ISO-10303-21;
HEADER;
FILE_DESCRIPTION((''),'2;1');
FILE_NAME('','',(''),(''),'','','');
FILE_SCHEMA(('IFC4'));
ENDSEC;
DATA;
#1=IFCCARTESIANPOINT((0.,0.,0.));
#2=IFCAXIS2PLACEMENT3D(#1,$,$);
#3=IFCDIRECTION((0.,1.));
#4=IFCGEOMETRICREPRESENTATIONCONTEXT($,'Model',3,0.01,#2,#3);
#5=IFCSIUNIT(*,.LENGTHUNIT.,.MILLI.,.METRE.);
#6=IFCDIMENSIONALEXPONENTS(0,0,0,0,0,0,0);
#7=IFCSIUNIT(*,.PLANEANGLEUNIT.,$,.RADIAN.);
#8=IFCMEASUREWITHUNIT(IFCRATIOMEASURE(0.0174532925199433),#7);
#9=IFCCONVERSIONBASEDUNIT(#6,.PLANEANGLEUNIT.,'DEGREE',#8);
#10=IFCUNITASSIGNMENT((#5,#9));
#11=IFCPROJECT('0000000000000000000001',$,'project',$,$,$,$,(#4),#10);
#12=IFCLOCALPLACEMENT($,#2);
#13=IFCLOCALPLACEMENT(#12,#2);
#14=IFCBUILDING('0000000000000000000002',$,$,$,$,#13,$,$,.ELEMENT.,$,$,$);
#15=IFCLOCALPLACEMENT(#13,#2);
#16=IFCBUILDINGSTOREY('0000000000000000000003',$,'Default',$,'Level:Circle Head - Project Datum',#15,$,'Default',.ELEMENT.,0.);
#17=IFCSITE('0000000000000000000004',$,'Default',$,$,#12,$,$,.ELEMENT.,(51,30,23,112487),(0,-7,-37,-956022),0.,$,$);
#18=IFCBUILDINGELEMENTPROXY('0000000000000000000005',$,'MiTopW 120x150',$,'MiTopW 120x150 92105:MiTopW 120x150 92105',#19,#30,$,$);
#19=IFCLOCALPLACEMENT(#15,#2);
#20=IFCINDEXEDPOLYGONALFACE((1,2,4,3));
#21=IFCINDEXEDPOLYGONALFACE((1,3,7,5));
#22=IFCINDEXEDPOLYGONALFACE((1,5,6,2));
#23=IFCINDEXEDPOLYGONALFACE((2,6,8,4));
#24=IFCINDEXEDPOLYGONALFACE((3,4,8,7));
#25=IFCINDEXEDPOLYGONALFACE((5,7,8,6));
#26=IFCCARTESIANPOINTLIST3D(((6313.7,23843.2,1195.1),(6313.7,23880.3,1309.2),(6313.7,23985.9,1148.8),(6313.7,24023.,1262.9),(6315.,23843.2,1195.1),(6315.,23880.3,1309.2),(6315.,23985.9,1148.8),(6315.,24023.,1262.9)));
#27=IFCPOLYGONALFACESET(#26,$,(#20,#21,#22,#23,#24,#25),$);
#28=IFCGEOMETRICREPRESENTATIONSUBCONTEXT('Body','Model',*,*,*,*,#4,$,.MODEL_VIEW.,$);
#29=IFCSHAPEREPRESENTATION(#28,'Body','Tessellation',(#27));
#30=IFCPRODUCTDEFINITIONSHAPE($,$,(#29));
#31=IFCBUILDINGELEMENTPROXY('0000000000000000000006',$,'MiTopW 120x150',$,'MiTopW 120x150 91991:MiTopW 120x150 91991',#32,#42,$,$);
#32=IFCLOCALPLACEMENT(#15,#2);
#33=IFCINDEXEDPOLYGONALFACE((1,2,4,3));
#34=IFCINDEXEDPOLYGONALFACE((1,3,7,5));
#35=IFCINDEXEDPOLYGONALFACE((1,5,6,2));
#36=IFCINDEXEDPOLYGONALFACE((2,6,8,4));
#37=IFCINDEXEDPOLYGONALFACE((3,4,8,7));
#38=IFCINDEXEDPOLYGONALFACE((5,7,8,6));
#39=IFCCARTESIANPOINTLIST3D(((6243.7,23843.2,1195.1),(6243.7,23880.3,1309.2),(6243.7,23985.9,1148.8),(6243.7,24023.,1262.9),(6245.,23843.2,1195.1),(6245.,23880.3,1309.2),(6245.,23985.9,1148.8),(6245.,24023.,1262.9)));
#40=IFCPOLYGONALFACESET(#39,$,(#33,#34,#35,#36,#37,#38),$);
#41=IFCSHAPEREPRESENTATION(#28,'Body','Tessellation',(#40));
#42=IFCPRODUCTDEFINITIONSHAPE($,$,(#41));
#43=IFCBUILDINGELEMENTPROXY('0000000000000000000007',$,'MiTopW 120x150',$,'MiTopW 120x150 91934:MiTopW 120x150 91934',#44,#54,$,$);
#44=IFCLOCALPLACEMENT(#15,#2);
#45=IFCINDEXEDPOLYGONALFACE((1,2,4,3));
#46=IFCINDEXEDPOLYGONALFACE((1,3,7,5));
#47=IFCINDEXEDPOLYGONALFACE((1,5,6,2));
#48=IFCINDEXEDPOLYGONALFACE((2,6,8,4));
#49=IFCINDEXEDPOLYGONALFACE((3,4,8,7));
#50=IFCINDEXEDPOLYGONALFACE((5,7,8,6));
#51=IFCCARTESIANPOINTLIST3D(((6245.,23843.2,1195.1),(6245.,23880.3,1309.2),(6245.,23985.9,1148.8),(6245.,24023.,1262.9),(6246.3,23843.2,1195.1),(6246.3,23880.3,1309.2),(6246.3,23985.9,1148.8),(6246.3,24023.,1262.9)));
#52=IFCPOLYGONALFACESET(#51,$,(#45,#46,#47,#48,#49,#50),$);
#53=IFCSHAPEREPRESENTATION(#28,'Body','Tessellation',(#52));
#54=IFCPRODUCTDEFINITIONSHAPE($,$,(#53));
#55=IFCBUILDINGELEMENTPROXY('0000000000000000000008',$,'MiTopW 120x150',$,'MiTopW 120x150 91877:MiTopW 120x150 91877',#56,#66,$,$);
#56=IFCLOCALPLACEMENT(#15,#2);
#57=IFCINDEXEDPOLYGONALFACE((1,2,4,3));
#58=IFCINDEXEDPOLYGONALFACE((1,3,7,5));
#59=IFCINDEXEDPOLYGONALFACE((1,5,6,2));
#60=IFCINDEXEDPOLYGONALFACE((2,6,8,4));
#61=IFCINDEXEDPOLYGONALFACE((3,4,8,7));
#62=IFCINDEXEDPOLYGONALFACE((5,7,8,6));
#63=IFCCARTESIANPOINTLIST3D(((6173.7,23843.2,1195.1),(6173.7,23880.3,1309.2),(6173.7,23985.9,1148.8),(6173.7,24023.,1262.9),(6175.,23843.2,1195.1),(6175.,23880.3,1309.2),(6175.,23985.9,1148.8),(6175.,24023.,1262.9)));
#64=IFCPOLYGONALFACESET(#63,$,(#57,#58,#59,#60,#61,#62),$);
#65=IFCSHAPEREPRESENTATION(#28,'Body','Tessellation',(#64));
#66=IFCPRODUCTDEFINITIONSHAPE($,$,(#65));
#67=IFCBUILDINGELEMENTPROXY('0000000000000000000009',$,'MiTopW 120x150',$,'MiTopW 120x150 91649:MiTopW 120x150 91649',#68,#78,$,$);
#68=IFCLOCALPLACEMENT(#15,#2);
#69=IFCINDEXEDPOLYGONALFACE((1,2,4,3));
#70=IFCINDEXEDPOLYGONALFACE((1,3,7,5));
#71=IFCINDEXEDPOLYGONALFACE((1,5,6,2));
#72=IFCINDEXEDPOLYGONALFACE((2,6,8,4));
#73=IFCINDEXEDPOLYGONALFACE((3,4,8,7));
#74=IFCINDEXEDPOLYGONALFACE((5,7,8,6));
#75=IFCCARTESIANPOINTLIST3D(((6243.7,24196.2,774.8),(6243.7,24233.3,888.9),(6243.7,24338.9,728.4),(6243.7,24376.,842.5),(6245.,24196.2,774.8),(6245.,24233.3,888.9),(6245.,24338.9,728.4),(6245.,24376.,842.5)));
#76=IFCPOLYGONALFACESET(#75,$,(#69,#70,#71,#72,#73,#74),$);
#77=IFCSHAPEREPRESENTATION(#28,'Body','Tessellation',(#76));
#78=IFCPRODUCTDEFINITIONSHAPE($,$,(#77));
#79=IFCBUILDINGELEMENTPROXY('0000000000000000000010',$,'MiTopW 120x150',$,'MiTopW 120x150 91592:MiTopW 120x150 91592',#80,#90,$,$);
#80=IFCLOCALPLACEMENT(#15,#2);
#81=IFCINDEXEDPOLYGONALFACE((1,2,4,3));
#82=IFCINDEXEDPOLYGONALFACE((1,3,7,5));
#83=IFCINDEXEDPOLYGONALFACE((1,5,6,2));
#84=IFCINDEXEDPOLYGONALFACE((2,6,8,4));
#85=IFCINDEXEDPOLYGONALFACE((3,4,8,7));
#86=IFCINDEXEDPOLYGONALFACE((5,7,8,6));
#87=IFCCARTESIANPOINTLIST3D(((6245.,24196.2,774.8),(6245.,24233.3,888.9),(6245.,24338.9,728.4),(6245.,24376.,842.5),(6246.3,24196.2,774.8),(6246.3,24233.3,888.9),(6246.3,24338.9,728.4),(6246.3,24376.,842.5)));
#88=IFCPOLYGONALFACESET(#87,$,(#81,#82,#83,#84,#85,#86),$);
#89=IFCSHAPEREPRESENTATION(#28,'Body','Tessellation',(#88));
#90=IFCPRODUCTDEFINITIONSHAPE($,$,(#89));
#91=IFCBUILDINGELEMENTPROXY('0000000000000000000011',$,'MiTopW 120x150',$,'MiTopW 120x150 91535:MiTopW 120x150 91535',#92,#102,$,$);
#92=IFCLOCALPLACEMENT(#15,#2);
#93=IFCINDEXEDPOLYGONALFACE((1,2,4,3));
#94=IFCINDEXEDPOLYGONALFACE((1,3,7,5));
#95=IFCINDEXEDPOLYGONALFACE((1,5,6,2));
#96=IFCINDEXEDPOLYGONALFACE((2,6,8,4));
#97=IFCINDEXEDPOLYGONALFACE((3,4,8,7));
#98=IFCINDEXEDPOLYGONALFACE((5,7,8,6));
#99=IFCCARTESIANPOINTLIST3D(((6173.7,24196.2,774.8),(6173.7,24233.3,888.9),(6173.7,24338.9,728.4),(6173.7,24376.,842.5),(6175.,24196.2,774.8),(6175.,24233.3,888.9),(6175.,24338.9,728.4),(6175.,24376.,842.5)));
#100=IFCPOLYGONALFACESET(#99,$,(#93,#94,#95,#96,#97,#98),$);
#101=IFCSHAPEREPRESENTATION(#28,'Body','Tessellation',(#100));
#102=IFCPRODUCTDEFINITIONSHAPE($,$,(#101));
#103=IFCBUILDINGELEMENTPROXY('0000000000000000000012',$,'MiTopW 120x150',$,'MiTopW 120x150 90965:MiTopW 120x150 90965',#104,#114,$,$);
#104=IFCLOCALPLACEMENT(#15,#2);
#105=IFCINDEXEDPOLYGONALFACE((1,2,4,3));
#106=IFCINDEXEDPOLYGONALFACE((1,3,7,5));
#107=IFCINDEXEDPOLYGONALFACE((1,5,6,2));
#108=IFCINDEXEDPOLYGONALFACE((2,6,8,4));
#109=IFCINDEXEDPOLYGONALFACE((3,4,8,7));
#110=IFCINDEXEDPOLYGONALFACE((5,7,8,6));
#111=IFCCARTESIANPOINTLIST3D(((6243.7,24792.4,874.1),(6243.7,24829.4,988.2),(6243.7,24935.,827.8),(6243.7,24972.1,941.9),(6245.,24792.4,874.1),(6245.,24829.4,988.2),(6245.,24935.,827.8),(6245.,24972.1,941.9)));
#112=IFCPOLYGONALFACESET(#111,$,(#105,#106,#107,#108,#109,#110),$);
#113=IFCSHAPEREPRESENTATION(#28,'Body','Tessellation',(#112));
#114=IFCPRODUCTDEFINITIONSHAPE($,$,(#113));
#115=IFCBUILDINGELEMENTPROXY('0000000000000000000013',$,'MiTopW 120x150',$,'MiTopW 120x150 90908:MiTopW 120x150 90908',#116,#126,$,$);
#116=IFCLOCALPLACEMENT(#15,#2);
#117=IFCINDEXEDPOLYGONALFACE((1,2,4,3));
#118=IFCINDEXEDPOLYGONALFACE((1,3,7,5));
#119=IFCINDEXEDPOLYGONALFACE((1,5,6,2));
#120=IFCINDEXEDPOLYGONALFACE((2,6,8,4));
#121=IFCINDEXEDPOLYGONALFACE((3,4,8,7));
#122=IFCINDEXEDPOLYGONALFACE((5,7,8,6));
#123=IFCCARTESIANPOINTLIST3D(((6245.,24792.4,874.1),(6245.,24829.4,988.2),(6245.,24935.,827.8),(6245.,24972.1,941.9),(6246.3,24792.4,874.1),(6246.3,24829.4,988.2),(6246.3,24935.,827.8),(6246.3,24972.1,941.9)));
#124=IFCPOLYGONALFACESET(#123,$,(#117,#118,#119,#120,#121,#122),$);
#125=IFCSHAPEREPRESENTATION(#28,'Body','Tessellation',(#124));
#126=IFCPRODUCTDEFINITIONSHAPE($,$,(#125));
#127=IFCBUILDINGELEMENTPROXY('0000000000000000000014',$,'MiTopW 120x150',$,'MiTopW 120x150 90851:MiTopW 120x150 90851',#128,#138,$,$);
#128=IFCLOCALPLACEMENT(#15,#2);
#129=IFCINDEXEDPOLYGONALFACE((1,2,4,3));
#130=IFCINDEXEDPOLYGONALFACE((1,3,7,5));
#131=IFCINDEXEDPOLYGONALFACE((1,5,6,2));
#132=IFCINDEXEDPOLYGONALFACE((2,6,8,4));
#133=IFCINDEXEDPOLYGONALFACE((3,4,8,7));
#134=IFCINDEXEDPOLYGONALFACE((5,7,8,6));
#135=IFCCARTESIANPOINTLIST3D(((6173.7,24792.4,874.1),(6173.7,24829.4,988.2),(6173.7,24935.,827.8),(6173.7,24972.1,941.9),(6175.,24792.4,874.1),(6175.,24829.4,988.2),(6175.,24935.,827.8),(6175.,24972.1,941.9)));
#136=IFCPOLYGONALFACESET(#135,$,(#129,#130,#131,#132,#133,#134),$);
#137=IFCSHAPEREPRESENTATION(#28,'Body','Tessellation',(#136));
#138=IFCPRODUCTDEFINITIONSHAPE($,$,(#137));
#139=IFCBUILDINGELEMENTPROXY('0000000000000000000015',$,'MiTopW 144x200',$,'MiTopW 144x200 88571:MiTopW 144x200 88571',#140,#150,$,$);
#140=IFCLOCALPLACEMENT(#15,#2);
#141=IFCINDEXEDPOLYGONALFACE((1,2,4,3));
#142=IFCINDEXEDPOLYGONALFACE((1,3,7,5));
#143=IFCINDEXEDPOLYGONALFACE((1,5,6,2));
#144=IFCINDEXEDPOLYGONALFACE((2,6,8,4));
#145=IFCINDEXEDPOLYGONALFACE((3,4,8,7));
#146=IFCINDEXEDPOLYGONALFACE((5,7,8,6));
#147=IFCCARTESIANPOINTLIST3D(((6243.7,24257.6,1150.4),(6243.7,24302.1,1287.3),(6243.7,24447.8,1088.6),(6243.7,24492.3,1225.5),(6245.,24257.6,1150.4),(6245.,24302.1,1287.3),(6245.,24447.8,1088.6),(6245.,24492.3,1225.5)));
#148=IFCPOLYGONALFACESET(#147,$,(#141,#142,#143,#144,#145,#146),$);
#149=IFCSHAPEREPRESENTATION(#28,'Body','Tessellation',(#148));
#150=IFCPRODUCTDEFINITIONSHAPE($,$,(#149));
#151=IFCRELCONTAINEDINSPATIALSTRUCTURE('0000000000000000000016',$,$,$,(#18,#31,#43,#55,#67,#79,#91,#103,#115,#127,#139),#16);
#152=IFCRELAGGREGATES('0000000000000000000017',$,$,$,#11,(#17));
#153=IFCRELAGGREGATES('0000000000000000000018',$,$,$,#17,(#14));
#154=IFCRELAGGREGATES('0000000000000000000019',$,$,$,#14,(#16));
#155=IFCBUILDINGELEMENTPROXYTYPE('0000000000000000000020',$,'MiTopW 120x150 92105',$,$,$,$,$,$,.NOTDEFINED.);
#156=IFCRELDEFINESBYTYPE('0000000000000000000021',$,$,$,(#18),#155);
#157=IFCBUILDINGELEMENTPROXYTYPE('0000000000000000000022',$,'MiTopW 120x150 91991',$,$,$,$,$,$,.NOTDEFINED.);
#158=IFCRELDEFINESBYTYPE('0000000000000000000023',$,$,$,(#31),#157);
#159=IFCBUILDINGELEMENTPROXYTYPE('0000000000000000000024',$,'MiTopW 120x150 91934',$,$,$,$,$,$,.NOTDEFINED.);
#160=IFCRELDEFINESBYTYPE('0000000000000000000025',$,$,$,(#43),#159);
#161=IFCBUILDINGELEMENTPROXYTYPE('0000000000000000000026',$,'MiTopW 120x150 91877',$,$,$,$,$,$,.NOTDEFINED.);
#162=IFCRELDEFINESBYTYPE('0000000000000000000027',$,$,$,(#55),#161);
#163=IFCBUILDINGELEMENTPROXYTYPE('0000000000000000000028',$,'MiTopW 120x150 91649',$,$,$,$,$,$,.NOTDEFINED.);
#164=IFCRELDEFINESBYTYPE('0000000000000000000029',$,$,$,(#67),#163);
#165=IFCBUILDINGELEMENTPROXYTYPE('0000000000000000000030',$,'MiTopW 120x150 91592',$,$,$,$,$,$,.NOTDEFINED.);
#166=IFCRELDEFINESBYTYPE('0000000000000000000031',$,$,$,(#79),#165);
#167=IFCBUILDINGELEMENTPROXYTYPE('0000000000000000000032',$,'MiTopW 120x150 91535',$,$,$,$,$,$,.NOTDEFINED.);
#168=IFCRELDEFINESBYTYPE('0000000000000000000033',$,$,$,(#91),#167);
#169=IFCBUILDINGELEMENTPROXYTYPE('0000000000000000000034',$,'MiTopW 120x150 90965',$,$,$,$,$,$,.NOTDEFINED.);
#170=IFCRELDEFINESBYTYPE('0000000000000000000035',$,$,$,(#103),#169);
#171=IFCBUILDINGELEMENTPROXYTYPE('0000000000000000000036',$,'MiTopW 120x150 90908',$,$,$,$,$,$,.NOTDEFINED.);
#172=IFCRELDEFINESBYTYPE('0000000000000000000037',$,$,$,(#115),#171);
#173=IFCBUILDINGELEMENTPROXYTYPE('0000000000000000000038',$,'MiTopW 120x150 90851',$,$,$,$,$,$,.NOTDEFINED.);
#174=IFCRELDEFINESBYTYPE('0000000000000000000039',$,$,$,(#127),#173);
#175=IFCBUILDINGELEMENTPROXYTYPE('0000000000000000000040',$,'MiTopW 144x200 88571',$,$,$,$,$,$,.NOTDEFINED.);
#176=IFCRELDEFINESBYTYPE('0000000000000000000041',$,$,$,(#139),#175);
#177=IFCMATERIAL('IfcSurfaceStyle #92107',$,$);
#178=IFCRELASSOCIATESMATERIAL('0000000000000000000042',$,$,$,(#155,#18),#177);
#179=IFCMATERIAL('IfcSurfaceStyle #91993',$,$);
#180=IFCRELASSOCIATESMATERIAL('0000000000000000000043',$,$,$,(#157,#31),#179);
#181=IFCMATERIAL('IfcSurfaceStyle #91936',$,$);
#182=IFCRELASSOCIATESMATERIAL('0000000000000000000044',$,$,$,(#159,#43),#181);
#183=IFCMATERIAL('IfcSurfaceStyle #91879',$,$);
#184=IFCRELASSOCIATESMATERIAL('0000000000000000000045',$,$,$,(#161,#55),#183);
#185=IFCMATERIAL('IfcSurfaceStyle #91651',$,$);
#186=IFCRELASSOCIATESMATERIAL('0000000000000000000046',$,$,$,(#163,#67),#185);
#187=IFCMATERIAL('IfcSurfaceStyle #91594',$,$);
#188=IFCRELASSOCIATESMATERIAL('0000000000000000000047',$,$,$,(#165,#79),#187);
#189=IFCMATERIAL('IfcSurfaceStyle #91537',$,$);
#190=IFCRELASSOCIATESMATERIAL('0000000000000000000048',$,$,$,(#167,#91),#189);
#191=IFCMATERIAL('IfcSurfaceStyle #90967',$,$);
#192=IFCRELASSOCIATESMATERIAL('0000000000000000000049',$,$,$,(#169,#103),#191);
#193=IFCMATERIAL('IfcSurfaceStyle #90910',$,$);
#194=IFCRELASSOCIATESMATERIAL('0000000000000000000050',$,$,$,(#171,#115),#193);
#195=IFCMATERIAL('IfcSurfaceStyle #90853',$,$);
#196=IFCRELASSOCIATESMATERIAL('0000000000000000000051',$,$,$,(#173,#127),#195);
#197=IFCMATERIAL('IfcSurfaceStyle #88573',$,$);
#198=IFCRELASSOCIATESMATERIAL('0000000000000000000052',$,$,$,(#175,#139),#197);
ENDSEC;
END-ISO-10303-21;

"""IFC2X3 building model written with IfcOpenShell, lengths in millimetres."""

from ifc_helpers import new_model, entity, si_unit, converted_unit, direction, frame, origin, place, context, subcontext, project, spatial, polyline, outline, extrude, source, transform, mapped, material, type_object, type_shapes, element, save


model = new_model("IFC2X3")

# Units and contexts
model_context = context("Model", 3, precision=0.01, world=origin(), true_north=direction((0.0, 1.0)))
body_context = subcontext(model_context, "Body", "Model", "MODEL_VIEW")
ifc_project = project(units=[si_unit("LENGTHUNIT", "METRE", prefix="MILLI"), converted_unit("PLANEANGLEUNIT", "DEGREE", entity("IfcRatioMeasure", 0.0174532925199433), si_unit("PLANEANGLEUNIT", "RADIAN"), dimensions=[0, 0, 0, 0, 0, 0, 0])], contexts=[model_context])

# Site, building, storey
site_placement = place(None, origin())
site = spatial("IfcSite", under=ifc_project, at=site_placement, Name="Default", CompositionType="ELEMENT", RefLatitude=(51, 30, 23, 112487), RefLongitude=(0, -7, -37, -956022), RefElevation=0.0)
building_placement = place(site_placement, origin())
building = spatial("IfcBuilding", under=site, at=building_placement, CompositionType="ELEMENT")
storey_placement = place(building_placement, origin())
storey = spatial("IfcBuildingStorey", under=building, at=storey_placement, Name="Default", ObjectType="Level:Circle Head - Project Datum", LongName="Default", CompositionType="ELEMENT", Elevation=0.0)

# Building element proxies
ifc_material_1 = material(Name="IfcSurfaceStyle #92107")
building_element_proxy_type_1 = type_object("IfcBuildingElementProxyType", Name="MiTopW 120x150 92105", PredefinedType="NOTDEFINED", material=ifc_material_1)
shared_shape_1 = source(origin(), body_context, "Body", "SweptSolid", [
    extrude(outline(polyline([(-75.0, -60.0), (75.0, -60.0), (75.0, 60.0), (-75.0, 60.0), (-75.0, -60.0)])), frame((75.0, 60.0, 0.0), z_axis=(0.0, 0.0, 1.0), x_axis=(-1.0, 0.0, 0.0)), (0.0, 0.0, 1.0), 1.3),
])
type_shapes(building_element_proxy_type_1, [shared_shape_1])
proxy_1_placement = place(building_placement, frame((6315.0, 23985.9, 1148.8), z_axis=(-1.0, 0.0, 0.0), x_axis=(0.0, -0.951057, 0.309017)))
element("IfcBuildingElementProxy", 1, at=proxy_1_placement, inside=storey, type_object=building_element_proxy_type_1, material=ifc_material_1, Name="MiTopW 120x150", ObjectType="MiTopW 120x150 92105:MiTopW 120x150 92105", context=body_context, shape_type="MappedRepresentation", body=[
    mapped(shared_shape_1, transform((0.0, 0.0, 0.0), scale=1.0)),
])
ifc_material_2 = material(Name="IfcSurfaceStyle #91993")
building_element_proxy_type_2 = type_object("IfcBuildingElementProxyType", Name="MiTopW 120x150 91991", PredefinedType="NOTDEFINED", material=ifc_material_2)
shared_shape_2 = source(origin(), body_context, "Body", "SweptSolid", [
    extrude(outline(polyline([(-75.0, -60.0), (75.0, -60.0), (75.0, 60.0), (-75.0, 60.0), (-75.0, -60.0)])), frame((75.0, 60.0, 0.0), z_axis=(0.0, 0.0, 1.0), x_axis=(-1.0, 0.0, 0.0)), (0.0, 0.0, 1.0), 1.3),
])
type_shapes(building_element_proxy_type_2, [shared_shape_2])
proxy_2_placement = place(building_placement, frame((6245.0, 23985.9, 1148.8), z_axis=(-1.0, 0.0, 0.0), x_axis=(0.0, -0.951057, 0.309017)))
element("IfcBuildingElementProxy", 2, at=proxy_2_placement, inside=storey, type_object=building_element_proxy_type_2, material=ifc_material_2, Name="MiTopW 120x150", ObjectType="MiTopW 120x150 91991:MiTopW 120x150 91991", context=body_context, shape_type="MappedRepresentation", body=[
    mapped(shared_shape_2, transform((0.0, 0.0, 0.0), scale=1.0)),
])
ifc_material_3 = material(Name="IfcSurfaceStyle #91936")
building_element_proxy_type_3 = type_object("IfcBuildingElementProxyType", Name="MiTopW 120x150 91934", PredefinedType="NOTDEFINED", material=ifc_material_3)
shared_shape_3 = source(origin(), body_context, "Body", "SweptSolid", [
    extrude(outline(polyline([(-75.0, -60.0), (75.0, -60.0), (75.0, 60.0), (-75.0, 60.0), (-75.0, -60.0)])), frame((75.0, 60.0, 0.0), z_axis=(0.0, 0.0, 1.0), x_axis=(-1.0, 0.0, 0.0)), (0.0, 0.0, 1.0), 1.3),
])
type_shapes(building_element_proxy_type_3, [shared_shape_3])
proxy_3_placement = place(building_placement, frame((6246.3, 23985.9, 1148.8), z_axis=(-1.0, 0.0, 0.0), x_axis=(0.0, -0.951057, 0.309017)))
element("IfcBuildingElementProxy", 3, at=proxy_3_placement, inside=storey, type_object=building_element_proxy_type_3, material=ifc_material_3, Name="MiTopW 120x150", ObjectType="MiTopW 120x150 91934:MiTopW 120x150 91934", context=body_context, shape_type="MappedRepresentation", body=[
    mapped(shared_shape_3, transform((0.0, 0.0, 0.0), scale=1.0)),
])
ifc_material_4 = material(Name="IfcSurfaceStyle #91879")
building_element_proxy_type_4 = type_object("IfcBuildingElementProxyType", Name="MiTopW 120x150 91877", PredefinedType="NOTDEFINED", material=ifc_material_4)
shared_shape_4 = source(origin(), body_context, "Body", "SweptSolid", [
    extrude(outline(polyline([(-75.0, -60.0), (75.0, -60.0), (75.0, 60.0), (-75.0, 60.0), (-75.0, -60.0)])), frame((75.0, 60.0, 0.0), z_axis=(0.0, 0.0, 1.0), x_axis=(-1.0, 0.0, 0.0)), (0.0, 0.0, 1.0), 1.3),
])
type_shapes(building_element_proxy_type_4, [shared_shape_4])
proxy_4_placement = place(building_placement, frame((6175.0, 23985.9, 1148.8), z_axis=(-1.0, 0.0, 0.0), x_axis=(0.0, -0.951057, 0.309017)))
element("IfcBuildingElementProxy", 4, at=proxy_4_placement, inside=storey, type_object=building_element_proxy_type_4, material=ifc_material_4, Name="MiTopW 120x150", ObjectType="MiTopW 120x150 91877:MiTopW 120x150 91877", context=body_context, shape_type="MappedRepresentation", body=[
    mapped(shared_shape_4, transform((0.0, 0.0, 0.0), scale=1.0)),
])
ifc_material_5 = material(Name="IfcSurfaceStyle #91651")
building_element_proxy_type_5 = type_object("IfcBuildingElementProxyType", Name="MiTopW 120x150 91649", PredefinedType="NOTDEFINED", material=ifc_material_5)
shared_shape_5 = source(origin(), body_context, "Body", "SweptSolid", [
    extrude(outline(polyline([(-75.0, -60.0), (75.0, -60.0), (75.0, 60.0), (-75.0, 60.0), (-75.0, -60.0)])), frame((75.0, 60.0, 0.0), z_axis=(0.0, 0.0, 1.0), x_axis=(-1.0, 0.0, 0.0)), (0.0, 0.0, 1.0), 1.3),
])
type_shapes(building_element_proxy_type_5, [shared_shape_5])
proxy_5_placement = place(building_placement, frame((6245.0, 24338.9, 728.4), z_axis=(-1.0, 0.0, 0.0), x_axis=(0.0, -0.951057, 0.309017)))
element("IfcBuildingElementProxy", 5, at=proxy_5_placement, inside=storey, type_object=building_element_proxy_type_5, material=ifc_material_5, Name="MiTopW 120x150", ObjectType="MiTopW 120x150 91649:MiTopW 120x150 91649", context=body_context, shape_type="MappedRepresentation", body=[
    mapped(shared_shape_5, transform((0.0, 0.0, 0.0), scale=1.0)),
])
ifc_material_6 = material(Name="IfcSurfaceStyle #91594")
building_element_proxy_type_6 = type_object("IfcBuildingElementProxyType", Name="MiTopW 120x150 91592", PredefinedType="NOTDEFINED", material=ifc_material_6)
shared_shape_6 = source(origin(), body_context, "Body", "SweptSolid", [
    extrude(outline(polyline([(-75.0, -60.0), (75.0, -60.0), (75.0, 60.0), (-75.0, 60.0), (-75.0, -60.0)])), frame((75.0, 60.0, 0.0), z_axis=(0.0, 0.0, 1.0), x_axis=(-1.0, 0.0, 0.0)), (0.0, 0.0, 1.0), 1.3),
])
type_shapes(building_element_proxy_type_6, [shared_shape_6])
proxy_6_placement = place(building_placement, frame((6246.3, 24338.9, 728.4), z_axis=(-1.0, 0.0, 0.0), x_axis=(0.0, -0.951057, 0.309017)))
element("IfcBuildingElementProxy", 6, at=proxy_6_placement, inside=storey, type_object=building_element_proxy_type_6, material=ifc_material_6, Name="MiTopW 120x150", ObjectType="MiTopW 120x150 91592:MiTopW 120x150 91592", context=body_context, shape_type="MappedRepresentation", body=[
    mapped(shared_shape_6, transform((0.0, 0.0, 0.0), scale=1.0)),
])
ifc_material_7 = material(Name="IfcSurfaceStyle #91537")
building_element_proxy_type_7 = type_object("IfcBuildingElementProxyType", Name="MiTopW 120x150 91535", PredefinedType="NOTDEFINED", material=ifc_material_7)
shared_shape_7 = source(origin(), body_context, "Body", "SweptSolid", [
    extrude(outline(polyline([(-75.0, -60.0), (75.0, -60.0), (75.0, 60.0), (-75.0, 60.0), (-75.0, -60.0)])), frame((75.0, 60.0, 0.0), z_axis=(0.0, 0.0, 1.0), x_axis=(-1.0, 0.0, 0.0)), (0.0, 0.0, 1.0), 1.3),
])
type_shapes(building_element_proxy_type_7, [shared_shape_7])
proxy_7_placement = place(building_placement, frame((6175.0, 24338.9, 728.4), z_axis=(-1.0, 0.0, 0.0), x_axis=(0.0, -0.951057, 0.309017)))
element("IfcBuildingElementProxy", 7, at=proxy_7_placement, inside=storey, type_object=building_element_proxy_type_7, material=ifc_material_7, Name="MiTopW 120x150", ObjectType="MiTopW 120x150 91535:MiTopW 120x150 91535", context=body_context, shape_type="MappedRepresentation", body=[
    mapped(shared_shape_7, transform((0.0, 0.0, 0.0), scale=1.0)),
])
ifc_material_8 = material(Name="IfcSurfaceStyle #90967")
building_element_proxy_type_8 = type_object("IfcBuildingElementProxyType", Name="MiTopW 120x150 90965", PredefinedType="NOTDEFINED", material=ifc_material_8)
shared_shape_8 = source(origin(), body_context, "Body", "SweptSolid", [
    extrude(outline(polyline([(-75.0, -60.0), (75.0, -60.0), (75.0, 60.0), (-75.0, 60.0), (-75.0, -60.0)])), frame((75.0, 60.0, 0.0), z_axis=(0.0, 0.0, 1.0), x_axis=(-1.0, 0.0, 0.0)), (0.0, 0.0, 1.0), 1.3),
])
type_shapes(building_element_proxy_type_8, [shared_shape_8])
proxy_8_placement = place(building_placement, frame((6245.0, 24935.0, 827.8), z_axis=(-1.0, 0.0, 0.0), x_axis=(0.0, -0.951057, 0.309017)))
element("IfcBuildingElementProxy", 8, at=proxy_8_placement, inside=storey, type_object=building_element_proxy_type_8, material=ifc_material_8, Name="MiTopW 120x150", ObjectType="MiTopW 120x150 90965:MiTopW 120x150 90965", context=body_context, shape_type="MappedRepresentation", body=[
    mapped(shared_shape_8, transform((0.0, 0.0, 0.0), scale=1.0)),
])
ifc_material_9 = material(Name="IfcSurfaceStyle #90910")
building_element_proxy_type_9 = type_object("IfcBuildingElementProxyType", Name="MiTopW 120x150 90908", PredefinedType="NOTDEFINED", material=ifc_material_9)
shared_shape_9 = source(origin(), body_context, "Body", "SweptSolid", [
    extrude(outline(polyline([(-75.0, -60.0), (75.0, -60.0), (75.0, 60.0), (-75.0, 60.0), (-75.0, -60.0)])), frame((75.0, 60.0, 0.0), z_axis=(0.0, 0.0, 1.0), x_axis=(-1.0, 0.0, 0.0)), (0.0, 0.0, 1.0), 1.3),
])
type_shapes(building_element_proxy_type_9, [shared_shape_9])
proxy_9_placement = place(building_placement, frame((6246.3, 24935.0, 827.8), z_axis=(-1.0, 0.0, 0.0), x_axis=(0.0, -0.951057, 0.309017)))
element("IfcBuildingElementProxy", 9, at=proxy_9_placement, inside=storey, type_object=building_element_proxy_type_9, material=ifc_material_9, Name="MiTopW 120x150", ObjectType="MiTopW 120x150 90908:MiTopW 120x150 90908", context=body_context, shape_type="MappedRepresentation", body=[
    mapped(shared_shape_9, transform((0.0, 0.0, 0.0), scale=1.0)),
])
ifc_material_10 = material(Name="IfcSurfaceStyle #90853")
building_element_proxy_type_10 = type_object("IfcBuildingElementProxyType", Name="MiTopW 120x150 90851", PredefinedType="NOTDEFINED", material=ifc_material_10)
shared_shape_10 = source(origin(), body_context, "Body", "SweptSolid", [
    extrude(outline(polyline([(-75.0, -60.0), (75.0, -60.0), (75.0, 60.0), (-75.0, 60.0), (-75.0, -60.0)])), frame((75.0, 60.0, 0.0), z_axis=(0.0, 0.0, 1.0), x_axis=(-1.0, 0.0, 0.0)), (0.0, 0.0, 1.0), 1.3),
])
type_shapes(building_element_proxy_type_10, [shared_shape_10])
proxy_10_placement = place(building_placement, frame((6175.0, 24935.0, 827.8), z_axis=(-1.0, 0.0, 0.0), x_axis=(0.0, -0.951057, 0.309017)))
element("IfcBuildingElementProxy", 10, at=proxy_10_placement, inside=storey, type_object=building_element_proxy_type_10, material=ifc_material_10, Name="MiTopW 120x150", ObjectType="MiTopW 120x150 90851:MiTopW 120x150 90851", context=body_context, shape_type="MappedRepresentation", body=[
    mapped(shared_shape_10, transform((0.0, 0.0, 0.0), scale=1.0)),
])
ifc_material_11 = material(Name="IfcSurfaceStyle #88573")
building_element_proxy_type_11 = type_object("IfcBuildingElementProxyType", Name="MiTopW 144x200 88571", PredefinedType="NOTDEFINED", material=ifc_material_11)
shared_shape_11 = source(origin(), body_context, "Body", "SweptSolid", [
    extrude(outline(polyline([(-100.0, -72.0), (100.0, -72.0), (100.0, 72.0), (-100.0, 72.0), (-100.0, -72.0)])), frame((100.0, 72.0, 0.0), z_axis=(0.0, 0.0, 1.0), x_axis=(-1.0, 0.0, 0.0)), (0.0, 0.0, 1.0), 1.3),
])
type_shapes(building_element_proxy_type_11, [shared_shape_11])
proxy_11_placement = place(building_placement, frame((6245.0, 24447.8, 1088.6), z_axis=(-1.0, 0.0, 0.0), x_axis=(0.0, -0.951057, 0.309017)))
element("IfcBuildingElementProxy", 11, at=proxy_11_placement, inside=storey, type_object=building_element_proxy_type_11, material=ifc_material_11, Name="MiTopW 144x200", ObjectType="MiTopW 144x200 88571:MiTopW 144x200 88571", context=body_context, shape_type="MappedRepresentation", body=[
    mapped(shared_shape_11, transform((0.0, 0.0, 0.0), scale=1.0)),
])

save(model, "model.ifc")
